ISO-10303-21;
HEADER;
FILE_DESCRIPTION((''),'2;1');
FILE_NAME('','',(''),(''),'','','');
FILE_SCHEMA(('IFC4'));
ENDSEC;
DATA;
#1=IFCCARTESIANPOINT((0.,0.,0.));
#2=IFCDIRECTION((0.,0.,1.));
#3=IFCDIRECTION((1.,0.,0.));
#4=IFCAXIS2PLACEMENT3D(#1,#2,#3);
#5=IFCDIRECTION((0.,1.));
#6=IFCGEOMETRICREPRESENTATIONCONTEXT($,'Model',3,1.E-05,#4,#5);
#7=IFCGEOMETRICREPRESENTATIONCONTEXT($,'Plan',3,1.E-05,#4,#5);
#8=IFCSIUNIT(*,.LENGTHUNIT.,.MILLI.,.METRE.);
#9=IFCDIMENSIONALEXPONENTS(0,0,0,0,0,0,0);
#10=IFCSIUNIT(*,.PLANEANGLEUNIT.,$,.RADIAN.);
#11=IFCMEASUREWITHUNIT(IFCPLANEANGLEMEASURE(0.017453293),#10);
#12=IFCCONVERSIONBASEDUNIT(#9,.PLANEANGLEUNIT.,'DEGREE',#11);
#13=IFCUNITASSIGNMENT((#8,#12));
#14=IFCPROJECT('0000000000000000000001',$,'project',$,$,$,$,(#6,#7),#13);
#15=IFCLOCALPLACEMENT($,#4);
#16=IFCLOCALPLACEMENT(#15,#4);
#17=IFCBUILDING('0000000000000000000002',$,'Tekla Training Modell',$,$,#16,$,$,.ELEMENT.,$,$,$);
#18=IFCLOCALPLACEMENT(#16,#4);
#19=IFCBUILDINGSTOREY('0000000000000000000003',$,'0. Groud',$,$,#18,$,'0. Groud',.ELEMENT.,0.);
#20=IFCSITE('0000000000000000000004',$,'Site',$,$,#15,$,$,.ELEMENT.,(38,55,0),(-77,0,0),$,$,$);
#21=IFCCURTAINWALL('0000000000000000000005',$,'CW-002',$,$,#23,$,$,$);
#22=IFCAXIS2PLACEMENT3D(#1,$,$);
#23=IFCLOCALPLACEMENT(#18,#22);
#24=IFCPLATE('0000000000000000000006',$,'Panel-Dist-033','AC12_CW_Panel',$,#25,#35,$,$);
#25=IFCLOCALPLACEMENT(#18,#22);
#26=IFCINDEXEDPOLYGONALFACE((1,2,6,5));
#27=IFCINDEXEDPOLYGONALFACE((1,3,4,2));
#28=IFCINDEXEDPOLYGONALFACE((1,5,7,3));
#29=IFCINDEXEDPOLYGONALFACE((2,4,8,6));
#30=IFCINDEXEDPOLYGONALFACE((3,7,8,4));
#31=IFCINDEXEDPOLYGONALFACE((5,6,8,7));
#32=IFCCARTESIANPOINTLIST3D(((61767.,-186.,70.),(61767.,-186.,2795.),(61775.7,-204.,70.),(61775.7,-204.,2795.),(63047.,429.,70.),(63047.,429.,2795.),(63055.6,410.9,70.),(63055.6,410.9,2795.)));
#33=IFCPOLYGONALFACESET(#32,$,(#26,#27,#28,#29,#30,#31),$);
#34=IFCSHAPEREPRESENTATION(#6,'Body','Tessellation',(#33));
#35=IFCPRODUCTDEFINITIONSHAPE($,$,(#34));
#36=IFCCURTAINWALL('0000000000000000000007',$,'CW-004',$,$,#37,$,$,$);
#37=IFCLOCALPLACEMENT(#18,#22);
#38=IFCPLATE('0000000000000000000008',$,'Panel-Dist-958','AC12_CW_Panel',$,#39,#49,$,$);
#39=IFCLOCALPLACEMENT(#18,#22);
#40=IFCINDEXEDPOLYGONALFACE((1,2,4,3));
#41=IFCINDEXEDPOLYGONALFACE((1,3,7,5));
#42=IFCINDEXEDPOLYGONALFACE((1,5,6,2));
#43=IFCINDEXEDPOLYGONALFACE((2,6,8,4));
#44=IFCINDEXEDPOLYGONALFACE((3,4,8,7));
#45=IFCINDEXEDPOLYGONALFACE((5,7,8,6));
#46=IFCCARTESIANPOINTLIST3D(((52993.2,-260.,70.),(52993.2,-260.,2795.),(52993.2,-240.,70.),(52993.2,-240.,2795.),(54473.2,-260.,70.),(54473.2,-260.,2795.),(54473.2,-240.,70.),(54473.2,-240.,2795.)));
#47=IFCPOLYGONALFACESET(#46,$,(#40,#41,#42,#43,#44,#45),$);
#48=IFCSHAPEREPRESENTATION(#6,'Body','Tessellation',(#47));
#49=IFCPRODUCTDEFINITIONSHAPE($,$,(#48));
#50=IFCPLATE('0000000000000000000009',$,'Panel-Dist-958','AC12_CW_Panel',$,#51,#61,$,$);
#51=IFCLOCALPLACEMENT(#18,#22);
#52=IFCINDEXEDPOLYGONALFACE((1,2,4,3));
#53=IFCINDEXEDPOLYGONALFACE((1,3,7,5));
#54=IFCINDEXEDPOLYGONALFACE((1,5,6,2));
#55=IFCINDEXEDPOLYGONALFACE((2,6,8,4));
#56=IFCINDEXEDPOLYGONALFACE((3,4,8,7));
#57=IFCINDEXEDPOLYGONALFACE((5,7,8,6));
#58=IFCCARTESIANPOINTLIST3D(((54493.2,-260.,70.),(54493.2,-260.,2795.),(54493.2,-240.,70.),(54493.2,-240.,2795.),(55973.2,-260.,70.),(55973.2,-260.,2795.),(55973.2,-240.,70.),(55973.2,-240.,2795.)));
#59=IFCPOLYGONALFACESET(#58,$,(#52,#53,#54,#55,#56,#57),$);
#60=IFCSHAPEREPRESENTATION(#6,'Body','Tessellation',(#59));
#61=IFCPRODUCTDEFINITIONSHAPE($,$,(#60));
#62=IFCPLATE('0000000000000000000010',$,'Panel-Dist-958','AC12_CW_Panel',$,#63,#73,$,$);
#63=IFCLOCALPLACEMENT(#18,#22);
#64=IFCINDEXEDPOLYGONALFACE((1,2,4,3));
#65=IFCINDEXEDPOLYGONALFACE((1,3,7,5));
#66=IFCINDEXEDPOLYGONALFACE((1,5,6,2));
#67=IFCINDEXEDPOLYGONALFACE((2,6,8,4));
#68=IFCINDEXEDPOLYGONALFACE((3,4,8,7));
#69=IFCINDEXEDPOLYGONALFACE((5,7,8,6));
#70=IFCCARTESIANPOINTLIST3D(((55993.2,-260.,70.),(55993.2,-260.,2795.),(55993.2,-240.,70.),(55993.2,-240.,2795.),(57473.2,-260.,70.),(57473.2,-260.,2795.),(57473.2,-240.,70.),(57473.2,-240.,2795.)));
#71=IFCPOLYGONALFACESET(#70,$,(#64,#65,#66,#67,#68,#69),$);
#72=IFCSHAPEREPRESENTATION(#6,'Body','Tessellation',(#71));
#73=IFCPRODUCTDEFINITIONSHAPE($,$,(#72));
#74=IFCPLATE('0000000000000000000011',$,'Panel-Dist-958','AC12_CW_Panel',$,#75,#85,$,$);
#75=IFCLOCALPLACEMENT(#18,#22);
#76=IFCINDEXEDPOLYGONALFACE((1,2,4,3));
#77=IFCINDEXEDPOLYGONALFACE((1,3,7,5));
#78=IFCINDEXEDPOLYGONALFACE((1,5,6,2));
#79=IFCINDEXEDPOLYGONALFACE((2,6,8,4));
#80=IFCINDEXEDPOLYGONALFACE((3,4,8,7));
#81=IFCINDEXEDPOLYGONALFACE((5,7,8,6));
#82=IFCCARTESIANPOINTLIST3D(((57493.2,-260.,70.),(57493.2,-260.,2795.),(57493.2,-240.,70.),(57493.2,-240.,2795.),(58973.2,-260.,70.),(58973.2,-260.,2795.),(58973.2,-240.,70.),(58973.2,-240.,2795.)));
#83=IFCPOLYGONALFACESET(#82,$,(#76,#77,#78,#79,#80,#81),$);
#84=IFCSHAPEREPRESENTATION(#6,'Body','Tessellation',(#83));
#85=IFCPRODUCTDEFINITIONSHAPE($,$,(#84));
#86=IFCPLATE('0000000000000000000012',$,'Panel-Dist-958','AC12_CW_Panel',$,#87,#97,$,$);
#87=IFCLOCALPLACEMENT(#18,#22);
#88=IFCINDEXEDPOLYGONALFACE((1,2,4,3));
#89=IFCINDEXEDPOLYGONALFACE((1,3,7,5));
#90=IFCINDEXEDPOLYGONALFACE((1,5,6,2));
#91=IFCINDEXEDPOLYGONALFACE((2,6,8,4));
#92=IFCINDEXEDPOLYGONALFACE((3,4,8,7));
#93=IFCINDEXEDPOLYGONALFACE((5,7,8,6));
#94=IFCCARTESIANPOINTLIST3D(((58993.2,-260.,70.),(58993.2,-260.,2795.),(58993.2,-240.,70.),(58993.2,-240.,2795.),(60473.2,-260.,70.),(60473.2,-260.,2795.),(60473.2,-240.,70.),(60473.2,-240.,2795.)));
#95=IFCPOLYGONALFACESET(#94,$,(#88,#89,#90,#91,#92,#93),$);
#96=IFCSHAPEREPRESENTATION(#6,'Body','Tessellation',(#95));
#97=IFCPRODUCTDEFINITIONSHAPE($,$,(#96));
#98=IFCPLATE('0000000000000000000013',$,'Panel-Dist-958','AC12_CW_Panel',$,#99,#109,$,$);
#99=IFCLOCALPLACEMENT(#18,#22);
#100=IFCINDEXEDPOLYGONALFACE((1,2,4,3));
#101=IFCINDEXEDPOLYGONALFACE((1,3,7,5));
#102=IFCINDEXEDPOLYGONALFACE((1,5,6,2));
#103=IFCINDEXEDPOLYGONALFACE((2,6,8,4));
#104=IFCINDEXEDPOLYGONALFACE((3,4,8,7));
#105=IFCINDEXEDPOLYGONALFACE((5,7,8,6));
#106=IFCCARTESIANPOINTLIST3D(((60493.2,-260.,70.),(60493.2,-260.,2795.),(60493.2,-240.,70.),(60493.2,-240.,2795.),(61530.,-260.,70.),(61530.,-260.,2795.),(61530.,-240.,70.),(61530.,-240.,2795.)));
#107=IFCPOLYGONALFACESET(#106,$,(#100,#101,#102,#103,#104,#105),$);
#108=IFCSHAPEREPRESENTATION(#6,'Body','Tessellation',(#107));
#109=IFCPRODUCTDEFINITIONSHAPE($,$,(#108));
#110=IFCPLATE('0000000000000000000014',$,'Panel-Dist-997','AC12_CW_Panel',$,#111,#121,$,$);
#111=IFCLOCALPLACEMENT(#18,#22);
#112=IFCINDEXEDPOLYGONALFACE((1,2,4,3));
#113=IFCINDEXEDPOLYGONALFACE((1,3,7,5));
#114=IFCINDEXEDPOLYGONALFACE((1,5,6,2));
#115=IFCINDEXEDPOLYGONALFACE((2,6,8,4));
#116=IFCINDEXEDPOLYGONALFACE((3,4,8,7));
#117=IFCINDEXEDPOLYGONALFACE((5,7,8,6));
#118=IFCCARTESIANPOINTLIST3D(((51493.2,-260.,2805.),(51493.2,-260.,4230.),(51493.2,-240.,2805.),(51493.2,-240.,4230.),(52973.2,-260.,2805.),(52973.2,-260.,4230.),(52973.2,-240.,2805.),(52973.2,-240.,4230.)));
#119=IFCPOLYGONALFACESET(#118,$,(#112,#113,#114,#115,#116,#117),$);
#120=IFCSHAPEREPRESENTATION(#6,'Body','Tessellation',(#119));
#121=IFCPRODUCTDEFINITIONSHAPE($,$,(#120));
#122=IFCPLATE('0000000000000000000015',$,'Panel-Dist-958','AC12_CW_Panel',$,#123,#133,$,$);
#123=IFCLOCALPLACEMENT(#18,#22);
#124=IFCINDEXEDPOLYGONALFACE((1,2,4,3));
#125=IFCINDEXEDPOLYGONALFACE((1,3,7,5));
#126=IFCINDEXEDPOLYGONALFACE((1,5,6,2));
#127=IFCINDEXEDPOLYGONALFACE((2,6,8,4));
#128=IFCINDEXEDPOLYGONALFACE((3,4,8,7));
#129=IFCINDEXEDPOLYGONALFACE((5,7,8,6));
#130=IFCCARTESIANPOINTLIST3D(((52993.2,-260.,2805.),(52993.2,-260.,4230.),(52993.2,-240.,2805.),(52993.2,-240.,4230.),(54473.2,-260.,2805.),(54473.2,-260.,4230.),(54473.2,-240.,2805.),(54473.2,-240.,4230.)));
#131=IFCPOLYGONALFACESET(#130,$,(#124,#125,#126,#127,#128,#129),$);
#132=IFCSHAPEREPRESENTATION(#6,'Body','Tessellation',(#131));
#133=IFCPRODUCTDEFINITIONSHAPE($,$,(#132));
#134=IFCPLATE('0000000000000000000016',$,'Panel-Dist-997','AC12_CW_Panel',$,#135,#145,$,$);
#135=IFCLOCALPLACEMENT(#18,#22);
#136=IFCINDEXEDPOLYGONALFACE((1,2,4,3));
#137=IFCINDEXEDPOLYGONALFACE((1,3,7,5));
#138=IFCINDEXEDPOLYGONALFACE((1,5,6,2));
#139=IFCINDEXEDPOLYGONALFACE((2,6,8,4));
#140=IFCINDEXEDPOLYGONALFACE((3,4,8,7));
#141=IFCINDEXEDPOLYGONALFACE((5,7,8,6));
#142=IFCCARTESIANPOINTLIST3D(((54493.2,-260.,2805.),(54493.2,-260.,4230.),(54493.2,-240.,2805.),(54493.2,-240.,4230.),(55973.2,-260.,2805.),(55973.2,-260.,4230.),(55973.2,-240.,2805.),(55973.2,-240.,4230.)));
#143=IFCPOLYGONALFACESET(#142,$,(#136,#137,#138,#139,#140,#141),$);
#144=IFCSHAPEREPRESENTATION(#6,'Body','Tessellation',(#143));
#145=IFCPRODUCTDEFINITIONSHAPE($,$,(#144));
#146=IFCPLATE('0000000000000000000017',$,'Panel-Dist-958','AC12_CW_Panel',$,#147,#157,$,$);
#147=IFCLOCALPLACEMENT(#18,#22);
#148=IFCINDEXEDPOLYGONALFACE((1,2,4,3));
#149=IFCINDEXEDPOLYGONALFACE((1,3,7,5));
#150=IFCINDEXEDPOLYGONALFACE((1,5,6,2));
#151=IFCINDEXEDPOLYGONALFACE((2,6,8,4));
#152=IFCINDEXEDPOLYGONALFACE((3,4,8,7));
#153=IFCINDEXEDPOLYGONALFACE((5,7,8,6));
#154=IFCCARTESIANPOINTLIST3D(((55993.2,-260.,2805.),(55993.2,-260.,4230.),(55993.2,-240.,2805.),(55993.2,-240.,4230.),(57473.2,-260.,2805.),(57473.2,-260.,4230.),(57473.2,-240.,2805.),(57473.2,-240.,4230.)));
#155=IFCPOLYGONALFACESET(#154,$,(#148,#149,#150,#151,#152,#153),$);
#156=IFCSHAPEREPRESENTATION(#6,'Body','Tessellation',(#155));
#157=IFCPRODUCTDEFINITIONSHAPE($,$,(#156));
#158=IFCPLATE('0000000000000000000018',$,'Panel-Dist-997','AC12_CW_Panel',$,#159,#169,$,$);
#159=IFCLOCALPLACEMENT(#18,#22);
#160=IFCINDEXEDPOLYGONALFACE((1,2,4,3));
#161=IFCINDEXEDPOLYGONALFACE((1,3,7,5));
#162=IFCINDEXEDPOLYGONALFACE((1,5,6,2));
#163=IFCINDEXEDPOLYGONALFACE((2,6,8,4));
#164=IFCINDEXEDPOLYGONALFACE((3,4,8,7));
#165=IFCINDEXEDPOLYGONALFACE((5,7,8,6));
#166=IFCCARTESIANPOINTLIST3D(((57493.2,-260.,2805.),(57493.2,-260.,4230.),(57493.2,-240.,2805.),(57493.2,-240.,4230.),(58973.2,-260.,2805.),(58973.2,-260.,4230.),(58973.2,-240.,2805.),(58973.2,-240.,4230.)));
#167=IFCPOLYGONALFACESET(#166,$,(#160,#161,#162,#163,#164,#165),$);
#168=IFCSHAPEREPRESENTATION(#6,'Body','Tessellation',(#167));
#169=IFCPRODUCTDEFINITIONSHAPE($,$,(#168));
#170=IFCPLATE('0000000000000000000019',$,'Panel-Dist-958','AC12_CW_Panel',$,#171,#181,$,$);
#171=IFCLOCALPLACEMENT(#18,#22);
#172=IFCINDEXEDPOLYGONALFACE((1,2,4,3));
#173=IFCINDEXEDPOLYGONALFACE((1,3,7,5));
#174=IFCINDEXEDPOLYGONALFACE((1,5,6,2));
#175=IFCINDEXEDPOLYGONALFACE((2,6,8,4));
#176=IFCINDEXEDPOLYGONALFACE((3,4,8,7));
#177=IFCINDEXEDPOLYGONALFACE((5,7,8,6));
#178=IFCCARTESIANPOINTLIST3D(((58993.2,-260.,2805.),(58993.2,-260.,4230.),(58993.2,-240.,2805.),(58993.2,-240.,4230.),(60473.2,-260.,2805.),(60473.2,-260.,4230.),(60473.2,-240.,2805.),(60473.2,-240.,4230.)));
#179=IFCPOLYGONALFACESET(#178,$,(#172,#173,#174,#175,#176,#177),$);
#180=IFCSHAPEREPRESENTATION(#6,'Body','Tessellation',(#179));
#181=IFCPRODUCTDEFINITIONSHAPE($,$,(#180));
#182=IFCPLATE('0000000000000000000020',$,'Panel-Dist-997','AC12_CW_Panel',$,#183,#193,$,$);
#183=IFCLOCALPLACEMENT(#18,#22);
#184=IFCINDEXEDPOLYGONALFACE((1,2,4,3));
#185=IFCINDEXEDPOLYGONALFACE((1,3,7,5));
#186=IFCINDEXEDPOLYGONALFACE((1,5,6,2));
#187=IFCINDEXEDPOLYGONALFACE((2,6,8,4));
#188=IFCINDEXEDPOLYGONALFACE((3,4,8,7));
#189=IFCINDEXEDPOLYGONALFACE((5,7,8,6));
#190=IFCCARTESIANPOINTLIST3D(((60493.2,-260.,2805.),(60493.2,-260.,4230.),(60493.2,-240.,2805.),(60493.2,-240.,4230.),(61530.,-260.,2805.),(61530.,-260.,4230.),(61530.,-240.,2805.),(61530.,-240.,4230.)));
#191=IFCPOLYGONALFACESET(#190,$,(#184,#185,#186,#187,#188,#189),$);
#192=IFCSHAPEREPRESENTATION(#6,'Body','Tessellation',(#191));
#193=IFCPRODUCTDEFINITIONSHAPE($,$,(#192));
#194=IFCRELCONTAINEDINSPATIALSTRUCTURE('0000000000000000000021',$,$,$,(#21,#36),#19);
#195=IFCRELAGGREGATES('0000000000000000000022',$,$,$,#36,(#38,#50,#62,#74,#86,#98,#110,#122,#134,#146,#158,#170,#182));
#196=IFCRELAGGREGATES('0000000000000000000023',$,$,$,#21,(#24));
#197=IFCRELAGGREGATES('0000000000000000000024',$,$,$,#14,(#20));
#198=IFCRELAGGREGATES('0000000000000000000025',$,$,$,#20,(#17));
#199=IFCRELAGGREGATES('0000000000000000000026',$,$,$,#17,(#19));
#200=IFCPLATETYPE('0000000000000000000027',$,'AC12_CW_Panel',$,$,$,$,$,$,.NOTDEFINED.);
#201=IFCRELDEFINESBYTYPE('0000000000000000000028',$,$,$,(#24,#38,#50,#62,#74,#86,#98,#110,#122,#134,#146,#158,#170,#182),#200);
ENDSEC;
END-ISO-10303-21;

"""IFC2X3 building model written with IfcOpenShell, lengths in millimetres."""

from ifc_helpers import new_model, entity, si_unit, converted_unit, direction, frame, origin_with_axes, place, context, project, spatial, polyline, outline, extrude, source, transform, mapped, type_object, element, aggregate, save


model = new_model("IFC2X3")

# Units and contexts
model_context = context("Model", 3, precision=1e-05, world=origin_with_axes(), true_north=direction((0.0, 1.0)))
plan_context = context("Plan", 3, precision=1e-05, world=origin_with_axes(), true_north=direction((0.0, 1.0)))
ifc_project = project(units=[si_unit("LENGTHUNIT", "METRE", prefix="MILLI"), converted_unit("PLANEANGLEUNIT", "DEGREE", entity("IfcPlaneAngleMeasure", 0.017453293), si_unit("PLANEANGLEUNIT", "RADIAN"), dimensions=[0, 0, 0, 0, 0, 0, 0])], contexts=[model_context, plan_context])

# Site, building, storey
site_placement = place(None, origin_with_axes())
site = spatial("IfcSite", under=ifc_project, at=site_placement, Name="Site", CompositionType="ELEMENT", RefLatitude=(38, 55, 0), RefLongitude=(-77, 0, 0))
building_placement = place(site_placement, origin_with_axes())
building = spatial("IfcBuilding", under=site, at=building_placement, Name="Tekla Training Modell", CompositionType="ELEMENT")
storey_placement = place(building_placement, origin_with_axes())
storey = spatial("IfcBuildingStorey", under=building, at=storey_placement, Name="0. Groud", LongName="0. Groud", CompositionType="ELEMENT", Elevation=0.0)

# Curtain wall, plate
curtain_wall_1_placement = place(storey_placement, frame((61708.3, -225.3, 0.0), z_axis=(0.0, 0.0, 1.0), x_axis=(0.901357, 0.433078, 0.0)))
curtain_wall_1 = element("IfcCurtainWall", 1, at=curtain_wall_1_placement, inside=storey, Name="CW-002")
plate_type = type_object("IfcPlateType", Name="AC12_CW_Panel", PredefinedType="NOTDEFINED")
shared_shape_1 = source(origin_with_axes(), model_context, "Body", "SweptSolid", [
    extrude(outline(polyline([(0.0, 0.0), (1420.0, 0.0), (1420.0, -20.0), (0.0, -20.0), (0.0, 0.0)])), origin_with_axes(), (0.0, 0.0, 1.0), 2725.0),
])
plate_1_placement = place(storey_placement, frame((61767.0, -186.0, 70.0), z_axis=(0.0, 0.0, 1.0), x_axis=(0.901357, 0.433078, 0.0)))
plate_1 = element("IfcPlate", 2, at=plate_1_placement, type_object=plate_type, Name="Panel-Dist-033", Description="AC12_CW_Panel", context=model_context, shape_type="MappedRepresentation", body=[
    mapped(shared_shape_1, transform((0.0, 0.0, 0.0), scale=1.0)),
])

# Curtain wall, plates
curtain_wall_2_placement = place(storey_placement, frame((3483.2, -250.0, 0.0), z_axis=(0.0, 0.0, 1.0), x_axis=(1.0, 0.0, 0.0)))
curtain_wall_2 = element("IfcCurtainWall", 3, at=curtain_wall_2_placement, inside=storey, Name="CW-004")
shared_shape_2 = source(origin_with_axes(), model_context, "Body", "SweptSolid", [
    extrude(outline(polyline([(0.0, 0.0), (1480.0, 0.0), (1480.0, -20.0), (0.0, -20.0), (0.0, 0.0)])), origin_with_axes(), (0.0, 0.0, 1.0), 2725.0),
])
plate_2_placement = place(storey_placement, frame((52993.2, -240.0, 70.0), z_axis=(0.0, 0.0, 1.0), x_axis=(1.0, 0.0, 0.0)))
plate_2 = element("IfcPlate", 4, at=plate_2_placement, type_object=plate_type, Name="Panel-Dist-958", Description="AC12_CW_Panel", context=model_context, shape_type="MappedRepresentation", body=[
    mapped(shared_shape_2, transform((0.0, 0.0, 0.0), scale=1.0)),
])
plate_3_placement = place(storey_placement, frame((54493.2, -240.0, 70.0), z_axis=(0.0, 0.0, 1.0), x_axis=(1.0, 0.0, 0.0)))
plate_3 = element("IfcPlate", 5, at=plate_3_placement, type_object=plate_type, Name="Panel-Dist-958", Description="AC12_CW_Panel", context=model_context, shape_type="MappedRepresentation", body=[
    mapped(shared_shape_2, transform((0.0, 0.0, 0.0), scale=1.0)),
])
plate_4_placement = place(storey_placement, frame((55993.2, -240.0, 70.0), z_axis=(0.0, 0.0, 1.0), x_axis=(1.0, 0.0, 0.0)))
plate_4 = element("IfcPlate", 6, at=plate_4_placement, type_object=plate_type, Name="Panel-Dist-958", Description="AC12_CW_Panel", context=model_context, shape_type="MappedRepresentation", body=[
    mapped(shared_shape_2, transform((0.0, 0.0, 0.0), scale=1.0)),
])
plate_5_placement = place(storey_placement, frame((57493.2, -240.0, 70.0), z_axis=(0.0, 0.0, 1.0), x_axis=(1.0, 0.0, 0.0)))
plate_5 = element("IfcPlate", 7, at=plate_5_placement, type_object=plate_type, Name="Panel-Dist-958", Description="AC12_CW_Panel", context=model_context, shape_type="MappedRepresentation", body=[
    mapped(shared_shape_2, transform((0.0, 0.0, 0.0), scale=1.0)),
])
plate_6_placement = place(storey_placement, frame((58993.2, -240.0, 70.0), z_axis=(0.0, 0.0, 1.0), x_axis=(1.0, 0.0, 0.0)))
plate_6 = element("IfcPlate", 8, at=plate_6_placement, type_object=plate_type, Name="Panel-Dist-958", Description="AC12_CW_Panel", context=model_context, shape_type="MappedRepresentation", body=[
    mapped(shared_shape_2, transform((0.0, 0.0, 0.0), scale=1.0)),
])
shared_shape_3 = source(origin_with_axes(), model_context, "Body", "SweptSolid", [
    extrude(outline(polyline([(0.0, 0.0), (1036.8, 0.0), (1036.8, -20.0), (0.0, -20.0), (0.0, 0.0)])), origin_with_axes(), (0.0, 0.0, 1.0), 2725.0),
])
plate_7_placement = place(storey_placement, frame((60493.2, -240.0, 70.0), z_axis=(0.0, 0.0, 1.0), x_axis=(1.0, 0.0, 0.0)))
plate_7 = element("IfcPlate", 9, at=plate_7_placement, type_object=plate_type, Name="Panel-Dist-958", Description="AC12_CW_Panel", context=model_context, shape_type="MappedRepresentation", body=[
    mapped(shared_shape_3, transform((0.0, 0.0, 0.0), scale=1.0)),
])
shared_shape_4 = source(origin_with_axes(), model_context, "Body", "SweptSolid", [
    extrude(outline(polyline([(0.0, 0.0), (1480.0, 0.0), (1480.0, -20.0), (0.0, -20.0), (0.0, 0.0)])), origin_with_axes(), (0.0, 0.0, 1.0), 1425.0),
])
plate_8_placement = place(storey_placement, frame((51493.2, -240.0, 2805.0), z_axis=(0.0, 0.0, 1.0), x_axis=(1.0, 0.0, 0.0)))
plate_8 = element("IfcPlate", 10, at=plate_8_placement, type_object=plate_type, Name="Panel-Dist-997", Description="AC12_CW_Panel", context=model_context, shape_type="MappedRepresentation", body=[
    mapped(shared_shape_4, transform((0.0, 0.0, 0.0), scale=1.0)),
])
plate_9_placement = place(storey_placement, frame((52993.2, -240.0, 2805.0), z_axis=(0.0, 0.0, 1.0), x_axis=(1.0, 0.0, 0.0)))
plate_9 = element("IfcPlate", 11, at=plate_9_placement, type_object=plate_type, Name="Panel-Dist-958", Description="AC12_CW_Panel", context=model_context, shape_type="MappedRepresentation", body=[
    mapped(shared_shape_4, transform((0.0, 0.0, 0.0), scale=1.0)),
])
plate_10_placement = place(storey_placement, frame((54493.2, -240.0, 2805.0), z_axis=(0.0, 0.0, 1.0), x_axis=(1.0, 0.0, 0.0)))
plate_10 = element("IfcPlate", 12, at=plate_10_placement, type_object=plate_type, Name="Panel-Dist-997", Description="AC12_CW_Panel", context=model_context, shape_type="MappedRepresentation", body=[
    mapped(shared_shape_4, transform((0.0, 0.0, 0.0), scale=1.0)),
])
plate_11_placement = place(storey_placement, frame((55993.2, -240.0, 2805.0), z_axis=(0.0, 0.0, 1.0), x_axis=(1.0, 0.0, 0.0)))
plate_11 = element("IfcPlate", 13, at=plate_11_placement, type_object=plate_type, Name="Panel-Dist-958", Description="AC12_CW_Panel", context=model_context, shape_type="MappedRepresentation", body=[
    mapped(shared_shape_4, transform((0.0, 0.0, 0.0), scale=1.0)),
])
plate_12_placement = place(storey_placement, frame((57493.2, -240.0, 2805.0), z_axis=(0.0, 0.0, 1.0), x_axis=(1.0, 0.0, 0.0)))
plate_12 = element("IfcPlate", 14, at=plate_12_placement, type_object=plate_type, Name="Panel-Dist-997", Description="AC12_CW_Panel", context=model_context, shape_type="MappedRepresentation", body=[
    mapped(shared_shape_4, transform((0.0, 0.0, 0.0), scale=1.0)),
])
plate_13_placement = place(storey_placement, frame((58993.2, -240.0, 2805.0), z_axis=(0.0, 0.0, 1.0), x_axis=(1.0, 0.0, 0.0)))
plate_13 = element("IfcPlate", 15, at=plate_13_placement, type_object=plate_type, Name="Panel-Dist-958", Description="AC12_CW_Panel", context=model_context, shape_type="MappedRepresentation", body=[
    mapped(shared_shape_4, transform((0.0, 0.0, 0.0), scale=1.0)),
])
shared_shape_5 = source(origin_with_axes(), model_context, "Body", "SweptSolid", [
    extrude(outline(polyline([(0.0, 0.0), (1036.8, 0.0), (1036.8, -20.0), (0.0, -20.0), (0.0, 0.0)])), origin_with_axes(), (0.0, 0.0, 1.0), 1425.0),
])
plate_14_placement = place(storey_placement, frame((60493.2, -240.0, 2805.0), z_axis=(0.0, 0.0, 1.0), x_axis=(1.0, 0.0, 0.0)))
plate_14 = element("IfcPlate", 16, at=plate_14_placement, type_object=plate_type, Name="Panel-Dist-997", Description="AC12_CW_Panel", context=model_context, shape_type="MappedRepresentation", body=[
    mapped(shared_shape_5, transform((0.0, 0.0, 0.0), scale=1.0)),
])

aggregate(curtain_wall_2, [plate_2, plate_3, plate_4, plate_5, plate_6, plate_7, plate_8, plate_9, plate_10, plate_11, plate_12, plate_13, plate_14])
aggregate(curtain_wall_1, [plate_1])

save(model, "model.ifc")
